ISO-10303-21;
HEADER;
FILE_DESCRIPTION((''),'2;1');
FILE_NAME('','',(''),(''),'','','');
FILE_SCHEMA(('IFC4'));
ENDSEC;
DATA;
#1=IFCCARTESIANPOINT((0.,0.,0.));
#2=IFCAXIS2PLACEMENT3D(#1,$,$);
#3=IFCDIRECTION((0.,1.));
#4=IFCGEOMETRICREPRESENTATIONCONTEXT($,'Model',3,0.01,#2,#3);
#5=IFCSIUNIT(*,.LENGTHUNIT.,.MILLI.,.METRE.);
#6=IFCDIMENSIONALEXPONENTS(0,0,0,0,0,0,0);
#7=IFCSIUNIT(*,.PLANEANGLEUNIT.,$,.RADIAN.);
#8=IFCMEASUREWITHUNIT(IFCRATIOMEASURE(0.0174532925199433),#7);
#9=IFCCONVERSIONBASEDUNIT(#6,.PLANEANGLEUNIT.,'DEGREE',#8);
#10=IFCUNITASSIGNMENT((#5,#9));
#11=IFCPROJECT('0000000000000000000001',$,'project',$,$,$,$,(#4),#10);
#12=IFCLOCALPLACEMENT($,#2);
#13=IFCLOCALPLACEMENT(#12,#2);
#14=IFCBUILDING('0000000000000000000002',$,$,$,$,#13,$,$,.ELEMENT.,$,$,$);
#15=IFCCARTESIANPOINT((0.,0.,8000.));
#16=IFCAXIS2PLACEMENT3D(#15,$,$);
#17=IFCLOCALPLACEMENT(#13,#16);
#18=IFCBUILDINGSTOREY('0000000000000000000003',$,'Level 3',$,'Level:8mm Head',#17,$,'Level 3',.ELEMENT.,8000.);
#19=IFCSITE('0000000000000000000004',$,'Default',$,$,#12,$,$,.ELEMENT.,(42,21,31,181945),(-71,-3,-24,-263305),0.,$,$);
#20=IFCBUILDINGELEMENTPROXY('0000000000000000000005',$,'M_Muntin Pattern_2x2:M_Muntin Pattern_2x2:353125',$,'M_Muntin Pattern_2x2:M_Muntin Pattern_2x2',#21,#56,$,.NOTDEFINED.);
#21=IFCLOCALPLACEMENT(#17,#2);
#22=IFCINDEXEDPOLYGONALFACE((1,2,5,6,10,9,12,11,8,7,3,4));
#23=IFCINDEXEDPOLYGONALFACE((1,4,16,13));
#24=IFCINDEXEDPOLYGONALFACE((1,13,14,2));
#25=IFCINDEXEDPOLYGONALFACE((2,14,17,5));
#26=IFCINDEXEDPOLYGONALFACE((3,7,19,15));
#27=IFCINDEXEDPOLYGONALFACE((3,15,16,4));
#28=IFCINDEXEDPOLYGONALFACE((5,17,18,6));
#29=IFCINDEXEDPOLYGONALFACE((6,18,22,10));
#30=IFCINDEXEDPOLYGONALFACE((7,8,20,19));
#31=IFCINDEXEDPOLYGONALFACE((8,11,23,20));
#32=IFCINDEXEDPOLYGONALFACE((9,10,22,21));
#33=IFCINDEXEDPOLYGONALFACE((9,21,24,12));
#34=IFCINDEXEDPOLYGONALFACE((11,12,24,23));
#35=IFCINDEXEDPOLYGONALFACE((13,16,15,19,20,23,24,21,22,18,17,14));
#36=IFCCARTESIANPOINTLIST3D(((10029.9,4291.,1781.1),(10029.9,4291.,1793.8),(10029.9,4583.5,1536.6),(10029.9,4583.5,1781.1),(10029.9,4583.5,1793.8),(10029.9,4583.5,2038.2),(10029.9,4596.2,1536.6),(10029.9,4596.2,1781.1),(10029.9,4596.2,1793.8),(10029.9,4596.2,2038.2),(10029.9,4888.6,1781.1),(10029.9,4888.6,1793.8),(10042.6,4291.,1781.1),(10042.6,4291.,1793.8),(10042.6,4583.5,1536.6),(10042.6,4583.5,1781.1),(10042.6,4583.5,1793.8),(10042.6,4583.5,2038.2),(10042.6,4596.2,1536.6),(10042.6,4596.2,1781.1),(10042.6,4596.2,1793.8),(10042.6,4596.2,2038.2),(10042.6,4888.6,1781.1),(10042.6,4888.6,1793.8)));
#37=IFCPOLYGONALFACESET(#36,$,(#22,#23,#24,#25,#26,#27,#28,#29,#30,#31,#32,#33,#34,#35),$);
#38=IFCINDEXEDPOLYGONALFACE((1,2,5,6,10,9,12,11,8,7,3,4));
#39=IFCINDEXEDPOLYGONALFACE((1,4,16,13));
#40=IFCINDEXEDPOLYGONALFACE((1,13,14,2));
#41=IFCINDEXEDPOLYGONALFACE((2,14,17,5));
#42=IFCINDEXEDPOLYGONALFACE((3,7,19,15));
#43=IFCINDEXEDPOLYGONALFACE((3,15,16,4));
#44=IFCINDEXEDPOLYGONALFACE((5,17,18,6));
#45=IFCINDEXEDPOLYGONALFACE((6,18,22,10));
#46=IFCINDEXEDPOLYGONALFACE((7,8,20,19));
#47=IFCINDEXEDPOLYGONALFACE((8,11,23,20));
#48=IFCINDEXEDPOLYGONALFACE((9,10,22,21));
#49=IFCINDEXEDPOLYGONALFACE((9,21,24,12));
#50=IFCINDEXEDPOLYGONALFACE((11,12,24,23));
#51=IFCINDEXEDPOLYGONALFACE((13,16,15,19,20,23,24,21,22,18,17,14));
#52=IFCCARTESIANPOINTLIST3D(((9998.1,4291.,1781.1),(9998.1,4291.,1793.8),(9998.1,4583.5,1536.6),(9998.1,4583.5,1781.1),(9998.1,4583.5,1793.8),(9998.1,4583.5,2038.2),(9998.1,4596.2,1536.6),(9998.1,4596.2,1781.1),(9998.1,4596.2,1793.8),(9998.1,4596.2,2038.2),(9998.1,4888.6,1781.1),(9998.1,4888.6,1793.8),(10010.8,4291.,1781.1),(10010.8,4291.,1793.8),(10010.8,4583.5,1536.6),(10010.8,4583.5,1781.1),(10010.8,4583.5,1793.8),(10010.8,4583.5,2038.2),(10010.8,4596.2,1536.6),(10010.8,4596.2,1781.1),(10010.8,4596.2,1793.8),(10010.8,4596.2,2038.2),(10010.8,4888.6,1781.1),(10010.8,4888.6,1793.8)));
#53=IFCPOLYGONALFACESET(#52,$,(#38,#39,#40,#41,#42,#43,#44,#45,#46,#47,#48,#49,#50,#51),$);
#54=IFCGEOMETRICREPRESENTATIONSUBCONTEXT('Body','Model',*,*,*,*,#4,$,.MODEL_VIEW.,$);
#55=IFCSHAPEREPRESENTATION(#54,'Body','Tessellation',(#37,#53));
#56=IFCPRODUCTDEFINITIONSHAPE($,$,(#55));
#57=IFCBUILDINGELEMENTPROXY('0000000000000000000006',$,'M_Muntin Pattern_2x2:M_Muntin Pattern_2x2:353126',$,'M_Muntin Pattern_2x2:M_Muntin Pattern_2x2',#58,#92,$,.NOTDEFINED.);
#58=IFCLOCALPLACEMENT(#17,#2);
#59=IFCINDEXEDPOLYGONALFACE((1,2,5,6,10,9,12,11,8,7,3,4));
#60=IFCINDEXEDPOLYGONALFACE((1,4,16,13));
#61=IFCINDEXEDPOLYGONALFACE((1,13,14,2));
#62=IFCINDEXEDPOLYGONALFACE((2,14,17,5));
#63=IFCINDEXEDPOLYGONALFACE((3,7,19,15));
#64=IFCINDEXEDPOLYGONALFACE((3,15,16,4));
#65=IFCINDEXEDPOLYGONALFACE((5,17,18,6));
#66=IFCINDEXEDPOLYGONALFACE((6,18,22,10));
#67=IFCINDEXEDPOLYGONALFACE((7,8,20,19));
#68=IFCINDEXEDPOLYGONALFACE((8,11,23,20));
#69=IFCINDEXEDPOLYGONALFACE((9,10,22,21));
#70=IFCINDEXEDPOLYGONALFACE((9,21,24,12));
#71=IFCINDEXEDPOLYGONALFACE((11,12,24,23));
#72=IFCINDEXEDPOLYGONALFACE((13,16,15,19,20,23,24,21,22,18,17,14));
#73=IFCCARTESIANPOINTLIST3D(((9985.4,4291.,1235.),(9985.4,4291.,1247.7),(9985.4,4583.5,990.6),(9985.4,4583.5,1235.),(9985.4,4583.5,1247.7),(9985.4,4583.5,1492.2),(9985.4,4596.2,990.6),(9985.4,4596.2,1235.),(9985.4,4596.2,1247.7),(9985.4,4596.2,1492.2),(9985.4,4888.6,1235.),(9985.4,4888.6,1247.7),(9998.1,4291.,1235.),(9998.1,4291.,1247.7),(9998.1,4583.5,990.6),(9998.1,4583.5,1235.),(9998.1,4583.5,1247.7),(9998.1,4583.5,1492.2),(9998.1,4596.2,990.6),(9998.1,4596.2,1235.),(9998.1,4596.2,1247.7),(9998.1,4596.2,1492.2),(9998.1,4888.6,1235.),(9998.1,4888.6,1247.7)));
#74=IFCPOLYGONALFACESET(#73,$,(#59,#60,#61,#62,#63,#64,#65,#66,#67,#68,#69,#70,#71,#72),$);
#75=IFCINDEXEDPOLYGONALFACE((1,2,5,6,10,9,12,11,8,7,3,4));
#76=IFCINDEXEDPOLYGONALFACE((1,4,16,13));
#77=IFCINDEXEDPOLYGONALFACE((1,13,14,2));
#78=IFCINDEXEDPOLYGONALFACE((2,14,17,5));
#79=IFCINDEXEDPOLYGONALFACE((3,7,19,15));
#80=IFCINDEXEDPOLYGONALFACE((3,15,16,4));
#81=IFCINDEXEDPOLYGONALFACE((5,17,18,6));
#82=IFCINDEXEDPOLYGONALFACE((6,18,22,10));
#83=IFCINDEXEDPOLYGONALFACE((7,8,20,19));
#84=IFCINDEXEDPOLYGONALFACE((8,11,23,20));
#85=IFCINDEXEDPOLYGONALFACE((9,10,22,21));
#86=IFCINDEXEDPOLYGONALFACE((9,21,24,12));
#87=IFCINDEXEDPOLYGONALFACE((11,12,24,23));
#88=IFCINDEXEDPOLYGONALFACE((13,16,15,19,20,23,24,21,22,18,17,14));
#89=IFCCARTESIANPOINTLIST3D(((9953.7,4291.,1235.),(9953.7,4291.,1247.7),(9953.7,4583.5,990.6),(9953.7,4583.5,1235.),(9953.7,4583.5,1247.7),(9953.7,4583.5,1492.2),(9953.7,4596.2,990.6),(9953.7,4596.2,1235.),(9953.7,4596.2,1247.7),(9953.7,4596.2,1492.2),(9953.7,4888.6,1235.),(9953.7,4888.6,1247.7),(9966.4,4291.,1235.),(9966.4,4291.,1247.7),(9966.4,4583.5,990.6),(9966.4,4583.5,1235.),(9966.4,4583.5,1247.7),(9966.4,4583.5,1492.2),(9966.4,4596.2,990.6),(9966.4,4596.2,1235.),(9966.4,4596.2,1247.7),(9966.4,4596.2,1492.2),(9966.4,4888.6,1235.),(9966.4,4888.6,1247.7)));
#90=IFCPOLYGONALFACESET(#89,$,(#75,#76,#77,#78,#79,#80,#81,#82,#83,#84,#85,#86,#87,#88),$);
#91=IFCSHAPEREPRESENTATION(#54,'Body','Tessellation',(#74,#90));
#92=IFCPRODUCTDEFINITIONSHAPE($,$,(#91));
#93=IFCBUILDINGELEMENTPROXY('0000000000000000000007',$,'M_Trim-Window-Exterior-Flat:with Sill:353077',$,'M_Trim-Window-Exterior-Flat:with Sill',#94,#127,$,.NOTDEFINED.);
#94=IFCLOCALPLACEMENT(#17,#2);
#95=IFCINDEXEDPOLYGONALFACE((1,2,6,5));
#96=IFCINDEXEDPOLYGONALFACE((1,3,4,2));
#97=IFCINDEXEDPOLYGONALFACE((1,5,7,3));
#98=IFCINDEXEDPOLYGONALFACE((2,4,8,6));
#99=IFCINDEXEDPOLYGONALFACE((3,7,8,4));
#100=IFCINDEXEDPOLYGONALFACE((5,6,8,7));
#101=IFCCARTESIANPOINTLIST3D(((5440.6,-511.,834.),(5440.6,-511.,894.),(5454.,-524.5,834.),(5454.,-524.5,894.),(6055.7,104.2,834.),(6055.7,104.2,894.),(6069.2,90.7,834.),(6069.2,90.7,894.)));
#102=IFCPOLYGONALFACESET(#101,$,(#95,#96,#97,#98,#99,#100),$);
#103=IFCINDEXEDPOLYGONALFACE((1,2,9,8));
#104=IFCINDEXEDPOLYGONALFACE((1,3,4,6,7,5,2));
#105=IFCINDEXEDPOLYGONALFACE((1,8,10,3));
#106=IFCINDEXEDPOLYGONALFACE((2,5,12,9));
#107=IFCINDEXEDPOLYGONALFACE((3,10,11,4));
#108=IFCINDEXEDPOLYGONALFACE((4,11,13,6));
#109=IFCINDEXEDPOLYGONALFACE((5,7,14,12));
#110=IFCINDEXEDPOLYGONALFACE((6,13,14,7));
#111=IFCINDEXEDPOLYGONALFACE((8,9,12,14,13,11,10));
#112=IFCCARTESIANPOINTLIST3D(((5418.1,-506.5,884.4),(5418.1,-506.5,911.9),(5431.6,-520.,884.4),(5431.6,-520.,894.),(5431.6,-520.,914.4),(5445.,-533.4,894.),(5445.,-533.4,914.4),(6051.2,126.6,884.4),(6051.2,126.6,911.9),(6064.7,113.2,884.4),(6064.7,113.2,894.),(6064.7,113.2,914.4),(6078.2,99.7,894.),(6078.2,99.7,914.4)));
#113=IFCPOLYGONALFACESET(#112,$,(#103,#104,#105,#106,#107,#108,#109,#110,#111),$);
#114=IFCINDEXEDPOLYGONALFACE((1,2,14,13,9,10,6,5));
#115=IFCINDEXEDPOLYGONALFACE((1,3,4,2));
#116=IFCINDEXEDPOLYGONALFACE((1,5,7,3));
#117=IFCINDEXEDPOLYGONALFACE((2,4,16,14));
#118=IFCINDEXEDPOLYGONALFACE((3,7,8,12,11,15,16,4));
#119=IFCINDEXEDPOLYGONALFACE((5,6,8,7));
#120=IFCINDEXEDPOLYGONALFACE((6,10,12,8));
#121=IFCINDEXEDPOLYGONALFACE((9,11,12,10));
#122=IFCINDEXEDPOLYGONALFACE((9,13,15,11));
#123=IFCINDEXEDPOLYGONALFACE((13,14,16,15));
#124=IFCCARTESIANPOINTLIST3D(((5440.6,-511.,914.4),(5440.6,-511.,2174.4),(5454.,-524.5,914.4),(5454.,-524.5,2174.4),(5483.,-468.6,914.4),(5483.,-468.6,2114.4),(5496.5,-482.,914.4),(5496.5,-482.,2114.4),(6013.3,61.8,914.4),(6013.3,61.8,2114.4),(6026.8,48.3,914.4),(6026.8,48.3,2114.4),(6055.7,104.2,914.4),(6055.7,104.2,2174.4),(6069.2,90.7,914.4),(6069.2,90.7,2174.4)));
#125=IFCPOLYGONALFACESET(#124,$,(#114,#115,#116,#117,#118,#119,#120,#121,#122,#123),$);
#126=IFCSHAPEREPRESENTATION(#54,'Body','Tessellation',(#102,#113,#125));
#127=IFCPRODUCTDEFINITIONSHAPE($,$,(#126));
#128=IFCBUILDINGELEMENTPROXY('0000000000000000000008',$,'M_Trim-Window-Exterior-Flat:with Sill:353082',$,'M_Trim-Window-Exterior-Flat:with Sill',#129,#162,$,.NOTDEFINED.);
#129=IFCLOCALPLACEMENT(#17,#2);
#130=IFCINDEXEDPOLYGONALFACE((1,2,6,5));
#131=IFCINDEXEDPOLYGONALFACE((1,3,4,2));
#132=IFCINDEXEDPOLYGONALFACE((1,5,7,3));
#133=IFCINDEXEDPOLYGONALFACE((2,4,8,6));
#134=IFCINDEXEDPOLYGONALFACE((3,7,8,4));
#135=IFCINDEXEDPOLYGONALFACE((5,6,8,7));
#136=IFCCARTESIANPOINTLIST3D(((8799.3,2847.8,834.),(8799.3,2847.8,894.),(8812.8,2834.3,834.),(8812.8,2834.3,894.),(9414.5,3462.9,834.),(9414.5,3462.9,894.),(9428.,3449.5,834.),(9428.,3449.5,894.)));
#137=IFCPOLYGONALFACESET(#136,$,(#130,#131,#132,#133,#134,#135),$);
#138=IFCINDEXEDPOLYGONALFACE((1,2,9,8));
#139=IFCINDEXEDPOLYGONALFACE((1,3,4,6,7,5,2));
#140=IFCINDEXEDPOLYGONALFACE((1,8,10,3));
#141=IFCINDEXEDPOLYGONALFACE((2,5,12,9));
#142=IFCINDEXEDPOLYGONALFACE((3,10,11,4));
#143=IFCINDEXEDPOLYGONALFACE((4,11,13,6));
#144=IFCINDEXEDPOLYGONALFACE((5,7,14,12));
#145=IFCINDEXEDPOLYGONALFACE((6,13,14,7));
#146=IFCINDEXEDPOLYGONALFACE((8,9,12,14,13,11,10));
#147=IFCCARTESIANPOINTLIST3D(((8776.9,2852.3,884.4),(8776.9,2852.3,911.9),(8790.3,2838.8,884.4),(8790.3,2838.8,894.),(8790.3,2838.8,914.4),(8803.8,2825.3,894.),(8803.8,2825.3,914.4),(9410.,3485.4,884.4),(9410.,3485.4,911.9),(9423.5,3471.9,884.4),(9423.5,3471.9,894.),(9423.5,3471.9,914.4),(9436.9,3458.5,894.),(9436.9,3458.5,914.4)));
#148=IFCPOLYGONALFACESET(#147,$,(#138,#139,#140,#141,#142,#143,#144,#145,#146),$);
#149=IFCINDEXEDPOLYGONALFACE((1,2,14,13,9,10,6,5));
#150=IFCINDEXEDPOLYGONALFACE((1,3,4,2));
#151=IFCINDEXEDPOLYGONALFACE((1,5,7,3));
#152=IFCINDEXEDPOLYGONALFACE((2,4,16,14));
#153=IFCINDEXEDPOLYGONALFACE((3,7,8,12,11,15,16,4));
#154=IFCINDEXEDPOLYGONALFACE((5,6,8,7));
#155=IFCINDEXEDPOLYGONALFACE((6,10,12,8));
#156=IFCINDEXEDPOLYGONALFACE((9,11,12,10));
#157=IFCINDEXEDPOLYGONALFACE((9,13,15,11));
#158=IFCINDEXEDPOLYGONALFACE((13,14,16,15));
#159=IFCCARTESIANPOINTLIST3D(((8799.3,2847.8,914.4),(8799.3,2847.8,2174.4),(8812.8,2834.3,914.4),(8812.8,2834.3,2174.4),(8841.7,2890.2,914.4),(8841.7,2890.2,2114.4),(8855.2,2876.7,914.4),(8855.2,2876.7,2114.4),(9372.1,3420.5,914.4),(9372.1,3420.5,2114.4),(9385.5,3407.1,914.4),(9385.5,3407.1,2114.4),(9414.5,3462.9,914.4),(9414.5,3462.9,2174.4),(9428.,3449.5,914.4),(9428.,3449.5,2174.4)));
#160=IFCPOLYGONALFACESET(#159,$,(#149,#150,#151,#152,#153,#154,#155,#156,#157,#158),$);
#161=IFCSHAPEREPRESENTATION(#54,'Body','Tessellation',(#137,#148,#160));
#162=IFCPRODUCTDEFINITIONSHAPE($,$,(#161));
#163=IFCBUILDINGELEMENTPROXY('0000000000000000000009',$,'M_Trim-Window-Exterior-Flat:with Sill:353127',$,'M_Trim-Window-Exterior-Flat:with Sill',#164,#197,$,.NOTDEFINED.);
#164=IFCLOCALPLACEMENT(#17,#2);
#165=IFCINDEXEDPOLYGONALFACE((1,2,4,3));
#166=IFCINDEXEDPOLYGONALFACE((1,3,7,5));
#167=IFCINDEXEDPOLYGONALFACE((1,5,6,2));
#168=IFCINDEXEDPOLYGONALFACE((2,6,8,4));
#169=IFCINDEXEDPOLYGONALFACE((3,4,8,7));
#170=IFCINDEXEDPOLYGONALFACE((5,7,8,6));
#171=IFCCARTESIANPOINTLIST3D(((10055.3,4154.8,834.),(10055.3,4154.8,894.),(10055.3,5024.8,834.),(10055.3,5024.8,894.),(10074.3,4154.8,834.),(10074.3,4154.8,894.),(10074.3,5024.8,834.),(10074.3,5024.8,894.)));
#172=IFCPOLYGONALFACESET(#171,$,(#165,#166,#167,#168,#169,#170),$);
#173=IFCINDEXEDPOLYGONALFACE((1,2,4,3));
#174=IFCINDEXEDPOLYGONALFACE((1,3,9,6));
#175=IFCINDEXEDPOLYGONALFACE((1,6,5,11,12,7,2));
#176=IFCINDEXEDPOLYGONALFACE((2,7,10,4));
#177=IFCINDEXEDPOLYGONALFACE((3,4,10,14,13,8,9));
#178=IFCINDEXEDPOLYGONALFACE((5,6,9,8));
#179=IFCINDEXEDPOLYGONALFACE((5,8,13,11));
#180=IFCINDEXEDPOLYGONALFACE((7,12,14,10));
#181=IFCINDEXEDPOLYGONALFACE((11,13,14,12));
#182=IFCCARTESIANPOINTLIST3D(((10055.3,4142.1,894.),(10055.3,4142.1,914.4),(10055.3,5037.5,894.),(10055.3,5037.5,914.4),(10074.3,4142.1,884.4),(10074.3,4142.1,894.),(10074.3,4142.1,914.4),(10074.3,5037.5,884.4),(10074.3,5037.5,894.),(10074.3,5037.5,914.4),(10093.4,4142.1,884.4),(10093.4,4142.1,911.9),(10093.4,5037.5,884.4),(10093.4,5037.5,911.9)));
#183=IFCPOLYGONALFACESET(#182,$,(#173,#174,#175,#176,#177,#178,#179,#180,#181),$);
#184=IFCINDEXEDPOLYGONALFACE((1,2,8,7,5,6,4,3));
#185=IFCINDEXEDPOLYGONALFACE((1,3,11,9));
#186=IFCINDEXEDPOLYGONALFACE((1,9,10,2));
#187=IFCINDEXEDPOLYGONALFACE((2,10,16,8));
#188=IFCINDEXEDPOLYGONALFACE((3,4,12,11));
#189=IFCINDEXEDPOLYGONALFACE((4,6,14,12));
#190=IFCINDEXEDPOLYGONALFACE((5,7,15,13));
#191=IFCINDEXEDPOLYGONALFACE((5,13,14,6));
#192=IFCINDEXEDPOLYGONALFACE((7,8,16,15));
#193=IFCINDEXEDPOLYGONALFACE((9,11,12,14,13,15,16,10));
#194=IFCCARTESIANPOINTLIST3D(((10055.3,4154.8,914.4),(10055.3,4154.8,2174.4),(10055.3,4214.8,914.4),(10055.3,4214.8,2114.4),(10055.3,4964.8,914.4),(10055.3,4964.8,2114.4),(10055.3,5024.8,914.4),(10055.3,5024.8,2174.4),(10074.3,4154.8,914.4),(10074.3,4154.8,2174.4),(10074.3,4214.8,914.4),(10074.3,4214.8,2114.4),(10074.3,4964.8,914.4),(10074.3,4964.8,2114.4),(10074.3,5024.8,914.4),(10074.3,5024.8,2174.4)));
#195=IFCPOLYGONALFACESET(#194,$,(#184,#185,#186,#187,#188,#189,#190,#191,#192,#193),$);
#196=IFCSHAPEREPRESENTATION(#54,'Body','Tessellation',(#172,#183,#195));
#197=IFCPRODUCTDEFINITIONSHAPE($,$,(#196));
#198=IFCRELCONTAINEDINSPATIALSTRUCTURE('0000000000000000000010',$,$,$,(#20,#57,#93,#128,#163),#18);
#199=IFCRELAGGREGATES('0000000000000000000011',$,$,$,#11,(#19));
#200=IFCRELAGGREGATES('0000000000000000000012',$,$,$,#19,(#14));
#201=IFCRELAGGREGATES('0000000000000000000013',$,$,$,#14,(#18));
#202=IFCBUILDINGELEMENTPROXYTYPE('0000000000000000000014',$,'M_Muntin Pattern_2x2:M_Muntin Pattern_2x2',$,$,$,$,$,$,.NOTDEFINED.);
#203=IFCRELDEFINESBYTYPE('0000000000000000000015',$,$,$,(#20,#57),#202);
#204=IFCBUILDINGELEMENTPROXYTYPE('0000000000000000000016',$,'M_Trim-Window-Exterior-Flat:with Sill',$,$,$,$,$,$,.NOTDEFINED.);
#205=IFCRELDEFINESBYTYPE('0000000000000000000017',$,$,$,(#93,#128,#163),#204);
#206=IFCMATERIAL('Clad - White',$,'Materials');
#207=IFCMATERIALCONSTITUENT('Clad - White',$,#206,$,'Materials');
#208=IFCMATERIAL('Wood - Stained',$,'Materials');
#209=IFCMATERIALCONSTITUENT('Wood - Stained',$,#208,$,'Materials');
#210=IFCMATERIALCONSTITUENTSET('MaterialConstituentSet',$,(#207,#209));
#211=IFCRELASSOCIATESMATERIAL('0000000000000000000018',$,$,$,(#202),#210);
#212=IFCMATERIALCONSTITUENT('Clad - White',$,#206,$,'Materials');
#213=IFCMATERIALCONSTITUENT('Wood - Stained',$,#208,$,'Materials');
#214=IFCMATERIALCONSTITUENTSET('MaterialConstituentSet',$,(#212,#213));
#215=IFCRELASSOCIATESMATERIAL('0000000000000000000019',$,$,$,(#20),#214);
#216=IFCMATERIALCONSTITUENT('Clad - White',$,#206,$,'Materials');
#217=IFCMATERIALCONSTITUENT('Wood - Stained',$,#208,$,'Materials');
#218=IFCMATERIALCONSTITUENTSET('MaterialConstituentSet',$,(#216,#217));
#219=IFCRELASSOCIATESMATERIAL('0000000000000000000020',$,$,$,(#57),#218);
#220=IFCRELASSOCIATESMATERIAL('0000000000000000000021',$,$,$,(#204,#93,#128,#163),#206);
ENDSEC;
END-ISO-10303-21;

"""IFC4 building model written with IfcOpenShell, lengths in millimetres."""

from ifc_helpers import new_model, entity, si_unit, converted_unit, direction, frame, frame_2d, origin, place, context, subcontext, project, spatial, polyline, rectangle, outline, extrude, source, transform, mapped, material, constituent, constituent_set, type_object, type_shapes, element, save


model = new_model("IFC4")

# Units and contexts
model_context = context("Model", 3, precision=0.01, world=origin(), true_north=direction((0.0, 1.0)))
body_context = subcontext(model_context, "Body", "Model", "MODEL_VIEW")
ifc_project = project(units=[si_unit("LENGTHUNIT", "METRE", prefix="MILLI"), converted_unit("PLANEANGLEUNIT", "DEGREE", entity("IfcRatioMeasure", 0.0174532925199433), si_unit("PLANEANGLEUNIT", "RADIAN"), dimensions=[0, 0, 0, 0, 0, 0, 0])], contexts=[model_context])

# Site, building, storey
site_placement = place(None, origin())
site = spatial("IfcSite", under=ifc_project, at=site_placement, Name="Default", CompositionType="ELEMENT", RefLatitude=(42, 21, 31, 181945), RefLongitude=(-71, -3, -24, -263305), RefElevation=0.0)
building_placement = place(site_placement, origin())
building = spatial("IfcBuilding", under=site, at=building_placement, CompositionType="ELEMENT")
storey_placement = place(building_placement, frame((0.0, 0.0, 8000.0)))
storey = spatial("IfcBuildingStorey", under=building, at=storey_placement, Name="Level 3", ObjectType="Level:8mm Head", LongName="Level 3", CompositionType="ELEMENT", Elevation=8000.0)

# Shared definitions
ifc_material_1 = material(Name="Wood - Stained", Category="Materials")

# Building element proxies
ifc_material_2 = material(Name="Clad - White", Category="Materials")
ifc_constituent_1 = constituent(ifc_material_2, Name="Clad - White", Category="Materials")
ifc_constituent_2 = constituent(ifc_material_1, Name="Wood - Stained", Category="Materials")
ifc_constituent_set_1 = constituent_set(constituents=[ifc_constituent_1, ifc_constituent_2], Name="MaterialConstituentSet")
building_element_proxy_type_1 = type_object("IfcBuildingElementProxyType", Name="M_Muntin Pattern_2x2:M_Muntin Pattern_2x2", PredefinedType="NOTDEFINED", material=ifc_constituent_set_1)
shared_shape_1 = source(origin(), body_context, "Body", "SweptSolid", [
    extrude(outline(polyline([(6.4, -6.4), (250.8, -6.4), (250.8, 6.3), (6.4, 6.3), (6.4, 298.8), (-6.3, 298.8), (-6.3, 6.3), (-250.8, 6.3), (-250.8, -6.4), (-6.3, -6.4), (-6.3, -298.8), (6.4, -298.8), (6.4, -6.4)])), frame((0.0, 9.5, 250.8), z_axis=(0.0, 1.0, 0.0), x_axis=(0.0, 0.0, 1.0)), (0.0, 0.0, 1.0), 12.7),
    extrude(outline(polyline([(6.4, -6.4), (250.8, -6.4), (250.8, 6.3), (6.4, 6.3), (6.4, 298.8), (-6.3, 298.8), (-6.3, 6.3), (-250.8, 6.3), (-250.8, -6.4), (-6.3, -6.4), (-6.3, -298.8), (6.4, -298.8), (6.4, -6.4)])), frame((0.0, -22.2, 250.8), z_axis=(0.0, 1.0, 0.0), x_axis=(0.0, 0.0, 1.0)), (0.0, 0.0, 1.0), 12.7),
])
type_shapes(building_element_proxy_type_1, [shared_shape_1])
ifc_constituent_3 = constituent(ifc_material_2, Name="Clad - White", Category="Materials")
ifc_constituent_4 = constituent(ifc_material_1, Name="Wood - Stained", Category="Materials")
ifc_constituent_set_2 = constituent_set(constituents=[ifc_constituent_3, ifc_constituent_4], Name="MaterialConstituentSet")
proxy_1_placement = place(storey_placement, frame((10020.3, 4589.8, 1536.6), z_axis=(0.0, 0.0, 1.0), x_axis=(0.0, -1.0, 0.0)))
element("IfcBuildingElementProxy", 1, at=proxy_1_placement, inside=storey, type_object=building_element_proxy_type_1, material=ifc_constituent_set_2, Name="M_Muntin Pattern_2x2:M_Muntin Pattern_2x2:353125", ObjectType="M_Muntin Pattern_2x2:M_Muntin Pattern_2x2", PredefinedType="NOTDEFINED", context=body_context, shape_type="MappedRepresentation", body=[
    mapped(shared_shape_1, transform((0.0, 0.0, 0.0), scale=1.0)),
])
ifc_constituent_5 = constituent(ifc_material_2, Name="Clad - White", Category="Materials")
ifc_constituent_6 = constituent(ifc_material_1, Name="Wood - Stained", Category="Materials")
ifc_constituent_set_3 = constituent_set(constituents=[ifc_constituent_5, ifc_constituent_6], Name="MaterialConstituentSet")
proxy_2_placement = place(storey_placement, frame((9975.9, 4589.8, 990.6), z_axis=(0.0, 0.0, 1.0), x_axis=(0.0, -1.0, 0.0)))
element("IfcBuildingElementProxy", 2, at=proxy_2_placement, inside=storey, type_object=building_element_proxy_type_1, material=ifc_constituent_set_3, Name="M_Muntin Pattern_2x2:M_Muntin Pattern_2x2:353126", ObjectType="M_Muntin Pattern_2x2:M_Muntin Pattern_2x2", PredefinedType="NOTDEFINED", context=body_context, shape_type="MappedRepresentation", body=[
    mapped(shared_shape_1, transform((0.0, 0.0, 0.0), scale=1.0)),
])
building_element_proxy_type_2 = type_object("IfcBuildingElementProxyType", Name="M_Trim-Window-Exterior-Flat:with Sill", PredefinedType="NOTDEFINED", material=ifc_material_2)
shared_shape_2 = source(origin(), body_context, "Body", "SweptSolid", [
    extrude(rectangle(XDim=870.0, YDim=60.0, at=frame_2d((0.0, 0.0), x_axis=(1.0, 0.0))), frame((0.0, -1250.4, 0.0), z_axis=(0.0, 0.0, 1.0), x_axis=(-1.0, 0.0, 0.0)), (0.0, 0.0, 1.0), 19.1),
    extrude(outline(polyline([(-19.0, -15.2), (0.0, -15.2), (0.0, -5.7), (19.0, -5.7), (19.0, 14.8), (0.0, 14.8), (-19.0, 12.3), (-19.0, -15.2)])), frame((-447.7, -1214.8, 19.0), z_axis=(1.0, 0.0, 0.0), x_axis=(0.0, 0.0, -1.0)), (0.0, 0.0, 1.0), 895.4),
    extrude(outline(polyline([(-645.0, -435.0), (615.0, -435.0), (615.0, -375.0), (-585.0, -375.0), (-585.0, 375.0), (615.0, 375.0), (615.0, 435.0), (-645.0, 435.0), (-645.0, -435.0)])), frame((0.0, -585.0, 0.0), z_axis=(0.0, 0.0, 1.0), x_axis=(0.0, -1.0, 0.0)), (0.0, 0.0, 1.0), 19.1),
])
type_shapes(building_element_proxy_type_2, [shared_shape_2])
for number, where, z_axis, x_axis, name in (
    (3, (5761.6, -216.9, 2114.4), (-0.707107, 0.707107, 0.0), (-0.707107, -0.707107, 0.0), "M_Trim-Window-Exterior-Flat:with Sill:353077"),
    (4, (9120.4, 3141.9, 2114.4), (-0.707107, 0.707107, 0.0), (-0.707107, -0.707107, 0.0), "M_Trim-Window-Exterior-Flat:with Sill:353082"),
    (5, (10055.3, 4589.8, 2114.4), (1.0, 0.0, 0.0), (0.0, 1.0, 0.0), "M_Trim-Window-Exterior-Flat:with Sill:353127"),
):
    element("IfcBuildingElementProxy", number, at=place(storey_placement, frame(where, z_axis=z_axis, x_axis=x_axis)), inside=storey, type_object=building_element_proxy_type_2, material=ifc_material_2, Name=name, ObjectType="M_Trim-Window-Exterior-Flat:with Sill", PredefinedType="NOTDEFINED", context=body_context, shape_type="MappedRepresentation", body=[
        mapped(shared_shape_2, transform((0.0, 0.0, 0.0), scale=1.0)),
    ])

save(model, "model.ifc")
